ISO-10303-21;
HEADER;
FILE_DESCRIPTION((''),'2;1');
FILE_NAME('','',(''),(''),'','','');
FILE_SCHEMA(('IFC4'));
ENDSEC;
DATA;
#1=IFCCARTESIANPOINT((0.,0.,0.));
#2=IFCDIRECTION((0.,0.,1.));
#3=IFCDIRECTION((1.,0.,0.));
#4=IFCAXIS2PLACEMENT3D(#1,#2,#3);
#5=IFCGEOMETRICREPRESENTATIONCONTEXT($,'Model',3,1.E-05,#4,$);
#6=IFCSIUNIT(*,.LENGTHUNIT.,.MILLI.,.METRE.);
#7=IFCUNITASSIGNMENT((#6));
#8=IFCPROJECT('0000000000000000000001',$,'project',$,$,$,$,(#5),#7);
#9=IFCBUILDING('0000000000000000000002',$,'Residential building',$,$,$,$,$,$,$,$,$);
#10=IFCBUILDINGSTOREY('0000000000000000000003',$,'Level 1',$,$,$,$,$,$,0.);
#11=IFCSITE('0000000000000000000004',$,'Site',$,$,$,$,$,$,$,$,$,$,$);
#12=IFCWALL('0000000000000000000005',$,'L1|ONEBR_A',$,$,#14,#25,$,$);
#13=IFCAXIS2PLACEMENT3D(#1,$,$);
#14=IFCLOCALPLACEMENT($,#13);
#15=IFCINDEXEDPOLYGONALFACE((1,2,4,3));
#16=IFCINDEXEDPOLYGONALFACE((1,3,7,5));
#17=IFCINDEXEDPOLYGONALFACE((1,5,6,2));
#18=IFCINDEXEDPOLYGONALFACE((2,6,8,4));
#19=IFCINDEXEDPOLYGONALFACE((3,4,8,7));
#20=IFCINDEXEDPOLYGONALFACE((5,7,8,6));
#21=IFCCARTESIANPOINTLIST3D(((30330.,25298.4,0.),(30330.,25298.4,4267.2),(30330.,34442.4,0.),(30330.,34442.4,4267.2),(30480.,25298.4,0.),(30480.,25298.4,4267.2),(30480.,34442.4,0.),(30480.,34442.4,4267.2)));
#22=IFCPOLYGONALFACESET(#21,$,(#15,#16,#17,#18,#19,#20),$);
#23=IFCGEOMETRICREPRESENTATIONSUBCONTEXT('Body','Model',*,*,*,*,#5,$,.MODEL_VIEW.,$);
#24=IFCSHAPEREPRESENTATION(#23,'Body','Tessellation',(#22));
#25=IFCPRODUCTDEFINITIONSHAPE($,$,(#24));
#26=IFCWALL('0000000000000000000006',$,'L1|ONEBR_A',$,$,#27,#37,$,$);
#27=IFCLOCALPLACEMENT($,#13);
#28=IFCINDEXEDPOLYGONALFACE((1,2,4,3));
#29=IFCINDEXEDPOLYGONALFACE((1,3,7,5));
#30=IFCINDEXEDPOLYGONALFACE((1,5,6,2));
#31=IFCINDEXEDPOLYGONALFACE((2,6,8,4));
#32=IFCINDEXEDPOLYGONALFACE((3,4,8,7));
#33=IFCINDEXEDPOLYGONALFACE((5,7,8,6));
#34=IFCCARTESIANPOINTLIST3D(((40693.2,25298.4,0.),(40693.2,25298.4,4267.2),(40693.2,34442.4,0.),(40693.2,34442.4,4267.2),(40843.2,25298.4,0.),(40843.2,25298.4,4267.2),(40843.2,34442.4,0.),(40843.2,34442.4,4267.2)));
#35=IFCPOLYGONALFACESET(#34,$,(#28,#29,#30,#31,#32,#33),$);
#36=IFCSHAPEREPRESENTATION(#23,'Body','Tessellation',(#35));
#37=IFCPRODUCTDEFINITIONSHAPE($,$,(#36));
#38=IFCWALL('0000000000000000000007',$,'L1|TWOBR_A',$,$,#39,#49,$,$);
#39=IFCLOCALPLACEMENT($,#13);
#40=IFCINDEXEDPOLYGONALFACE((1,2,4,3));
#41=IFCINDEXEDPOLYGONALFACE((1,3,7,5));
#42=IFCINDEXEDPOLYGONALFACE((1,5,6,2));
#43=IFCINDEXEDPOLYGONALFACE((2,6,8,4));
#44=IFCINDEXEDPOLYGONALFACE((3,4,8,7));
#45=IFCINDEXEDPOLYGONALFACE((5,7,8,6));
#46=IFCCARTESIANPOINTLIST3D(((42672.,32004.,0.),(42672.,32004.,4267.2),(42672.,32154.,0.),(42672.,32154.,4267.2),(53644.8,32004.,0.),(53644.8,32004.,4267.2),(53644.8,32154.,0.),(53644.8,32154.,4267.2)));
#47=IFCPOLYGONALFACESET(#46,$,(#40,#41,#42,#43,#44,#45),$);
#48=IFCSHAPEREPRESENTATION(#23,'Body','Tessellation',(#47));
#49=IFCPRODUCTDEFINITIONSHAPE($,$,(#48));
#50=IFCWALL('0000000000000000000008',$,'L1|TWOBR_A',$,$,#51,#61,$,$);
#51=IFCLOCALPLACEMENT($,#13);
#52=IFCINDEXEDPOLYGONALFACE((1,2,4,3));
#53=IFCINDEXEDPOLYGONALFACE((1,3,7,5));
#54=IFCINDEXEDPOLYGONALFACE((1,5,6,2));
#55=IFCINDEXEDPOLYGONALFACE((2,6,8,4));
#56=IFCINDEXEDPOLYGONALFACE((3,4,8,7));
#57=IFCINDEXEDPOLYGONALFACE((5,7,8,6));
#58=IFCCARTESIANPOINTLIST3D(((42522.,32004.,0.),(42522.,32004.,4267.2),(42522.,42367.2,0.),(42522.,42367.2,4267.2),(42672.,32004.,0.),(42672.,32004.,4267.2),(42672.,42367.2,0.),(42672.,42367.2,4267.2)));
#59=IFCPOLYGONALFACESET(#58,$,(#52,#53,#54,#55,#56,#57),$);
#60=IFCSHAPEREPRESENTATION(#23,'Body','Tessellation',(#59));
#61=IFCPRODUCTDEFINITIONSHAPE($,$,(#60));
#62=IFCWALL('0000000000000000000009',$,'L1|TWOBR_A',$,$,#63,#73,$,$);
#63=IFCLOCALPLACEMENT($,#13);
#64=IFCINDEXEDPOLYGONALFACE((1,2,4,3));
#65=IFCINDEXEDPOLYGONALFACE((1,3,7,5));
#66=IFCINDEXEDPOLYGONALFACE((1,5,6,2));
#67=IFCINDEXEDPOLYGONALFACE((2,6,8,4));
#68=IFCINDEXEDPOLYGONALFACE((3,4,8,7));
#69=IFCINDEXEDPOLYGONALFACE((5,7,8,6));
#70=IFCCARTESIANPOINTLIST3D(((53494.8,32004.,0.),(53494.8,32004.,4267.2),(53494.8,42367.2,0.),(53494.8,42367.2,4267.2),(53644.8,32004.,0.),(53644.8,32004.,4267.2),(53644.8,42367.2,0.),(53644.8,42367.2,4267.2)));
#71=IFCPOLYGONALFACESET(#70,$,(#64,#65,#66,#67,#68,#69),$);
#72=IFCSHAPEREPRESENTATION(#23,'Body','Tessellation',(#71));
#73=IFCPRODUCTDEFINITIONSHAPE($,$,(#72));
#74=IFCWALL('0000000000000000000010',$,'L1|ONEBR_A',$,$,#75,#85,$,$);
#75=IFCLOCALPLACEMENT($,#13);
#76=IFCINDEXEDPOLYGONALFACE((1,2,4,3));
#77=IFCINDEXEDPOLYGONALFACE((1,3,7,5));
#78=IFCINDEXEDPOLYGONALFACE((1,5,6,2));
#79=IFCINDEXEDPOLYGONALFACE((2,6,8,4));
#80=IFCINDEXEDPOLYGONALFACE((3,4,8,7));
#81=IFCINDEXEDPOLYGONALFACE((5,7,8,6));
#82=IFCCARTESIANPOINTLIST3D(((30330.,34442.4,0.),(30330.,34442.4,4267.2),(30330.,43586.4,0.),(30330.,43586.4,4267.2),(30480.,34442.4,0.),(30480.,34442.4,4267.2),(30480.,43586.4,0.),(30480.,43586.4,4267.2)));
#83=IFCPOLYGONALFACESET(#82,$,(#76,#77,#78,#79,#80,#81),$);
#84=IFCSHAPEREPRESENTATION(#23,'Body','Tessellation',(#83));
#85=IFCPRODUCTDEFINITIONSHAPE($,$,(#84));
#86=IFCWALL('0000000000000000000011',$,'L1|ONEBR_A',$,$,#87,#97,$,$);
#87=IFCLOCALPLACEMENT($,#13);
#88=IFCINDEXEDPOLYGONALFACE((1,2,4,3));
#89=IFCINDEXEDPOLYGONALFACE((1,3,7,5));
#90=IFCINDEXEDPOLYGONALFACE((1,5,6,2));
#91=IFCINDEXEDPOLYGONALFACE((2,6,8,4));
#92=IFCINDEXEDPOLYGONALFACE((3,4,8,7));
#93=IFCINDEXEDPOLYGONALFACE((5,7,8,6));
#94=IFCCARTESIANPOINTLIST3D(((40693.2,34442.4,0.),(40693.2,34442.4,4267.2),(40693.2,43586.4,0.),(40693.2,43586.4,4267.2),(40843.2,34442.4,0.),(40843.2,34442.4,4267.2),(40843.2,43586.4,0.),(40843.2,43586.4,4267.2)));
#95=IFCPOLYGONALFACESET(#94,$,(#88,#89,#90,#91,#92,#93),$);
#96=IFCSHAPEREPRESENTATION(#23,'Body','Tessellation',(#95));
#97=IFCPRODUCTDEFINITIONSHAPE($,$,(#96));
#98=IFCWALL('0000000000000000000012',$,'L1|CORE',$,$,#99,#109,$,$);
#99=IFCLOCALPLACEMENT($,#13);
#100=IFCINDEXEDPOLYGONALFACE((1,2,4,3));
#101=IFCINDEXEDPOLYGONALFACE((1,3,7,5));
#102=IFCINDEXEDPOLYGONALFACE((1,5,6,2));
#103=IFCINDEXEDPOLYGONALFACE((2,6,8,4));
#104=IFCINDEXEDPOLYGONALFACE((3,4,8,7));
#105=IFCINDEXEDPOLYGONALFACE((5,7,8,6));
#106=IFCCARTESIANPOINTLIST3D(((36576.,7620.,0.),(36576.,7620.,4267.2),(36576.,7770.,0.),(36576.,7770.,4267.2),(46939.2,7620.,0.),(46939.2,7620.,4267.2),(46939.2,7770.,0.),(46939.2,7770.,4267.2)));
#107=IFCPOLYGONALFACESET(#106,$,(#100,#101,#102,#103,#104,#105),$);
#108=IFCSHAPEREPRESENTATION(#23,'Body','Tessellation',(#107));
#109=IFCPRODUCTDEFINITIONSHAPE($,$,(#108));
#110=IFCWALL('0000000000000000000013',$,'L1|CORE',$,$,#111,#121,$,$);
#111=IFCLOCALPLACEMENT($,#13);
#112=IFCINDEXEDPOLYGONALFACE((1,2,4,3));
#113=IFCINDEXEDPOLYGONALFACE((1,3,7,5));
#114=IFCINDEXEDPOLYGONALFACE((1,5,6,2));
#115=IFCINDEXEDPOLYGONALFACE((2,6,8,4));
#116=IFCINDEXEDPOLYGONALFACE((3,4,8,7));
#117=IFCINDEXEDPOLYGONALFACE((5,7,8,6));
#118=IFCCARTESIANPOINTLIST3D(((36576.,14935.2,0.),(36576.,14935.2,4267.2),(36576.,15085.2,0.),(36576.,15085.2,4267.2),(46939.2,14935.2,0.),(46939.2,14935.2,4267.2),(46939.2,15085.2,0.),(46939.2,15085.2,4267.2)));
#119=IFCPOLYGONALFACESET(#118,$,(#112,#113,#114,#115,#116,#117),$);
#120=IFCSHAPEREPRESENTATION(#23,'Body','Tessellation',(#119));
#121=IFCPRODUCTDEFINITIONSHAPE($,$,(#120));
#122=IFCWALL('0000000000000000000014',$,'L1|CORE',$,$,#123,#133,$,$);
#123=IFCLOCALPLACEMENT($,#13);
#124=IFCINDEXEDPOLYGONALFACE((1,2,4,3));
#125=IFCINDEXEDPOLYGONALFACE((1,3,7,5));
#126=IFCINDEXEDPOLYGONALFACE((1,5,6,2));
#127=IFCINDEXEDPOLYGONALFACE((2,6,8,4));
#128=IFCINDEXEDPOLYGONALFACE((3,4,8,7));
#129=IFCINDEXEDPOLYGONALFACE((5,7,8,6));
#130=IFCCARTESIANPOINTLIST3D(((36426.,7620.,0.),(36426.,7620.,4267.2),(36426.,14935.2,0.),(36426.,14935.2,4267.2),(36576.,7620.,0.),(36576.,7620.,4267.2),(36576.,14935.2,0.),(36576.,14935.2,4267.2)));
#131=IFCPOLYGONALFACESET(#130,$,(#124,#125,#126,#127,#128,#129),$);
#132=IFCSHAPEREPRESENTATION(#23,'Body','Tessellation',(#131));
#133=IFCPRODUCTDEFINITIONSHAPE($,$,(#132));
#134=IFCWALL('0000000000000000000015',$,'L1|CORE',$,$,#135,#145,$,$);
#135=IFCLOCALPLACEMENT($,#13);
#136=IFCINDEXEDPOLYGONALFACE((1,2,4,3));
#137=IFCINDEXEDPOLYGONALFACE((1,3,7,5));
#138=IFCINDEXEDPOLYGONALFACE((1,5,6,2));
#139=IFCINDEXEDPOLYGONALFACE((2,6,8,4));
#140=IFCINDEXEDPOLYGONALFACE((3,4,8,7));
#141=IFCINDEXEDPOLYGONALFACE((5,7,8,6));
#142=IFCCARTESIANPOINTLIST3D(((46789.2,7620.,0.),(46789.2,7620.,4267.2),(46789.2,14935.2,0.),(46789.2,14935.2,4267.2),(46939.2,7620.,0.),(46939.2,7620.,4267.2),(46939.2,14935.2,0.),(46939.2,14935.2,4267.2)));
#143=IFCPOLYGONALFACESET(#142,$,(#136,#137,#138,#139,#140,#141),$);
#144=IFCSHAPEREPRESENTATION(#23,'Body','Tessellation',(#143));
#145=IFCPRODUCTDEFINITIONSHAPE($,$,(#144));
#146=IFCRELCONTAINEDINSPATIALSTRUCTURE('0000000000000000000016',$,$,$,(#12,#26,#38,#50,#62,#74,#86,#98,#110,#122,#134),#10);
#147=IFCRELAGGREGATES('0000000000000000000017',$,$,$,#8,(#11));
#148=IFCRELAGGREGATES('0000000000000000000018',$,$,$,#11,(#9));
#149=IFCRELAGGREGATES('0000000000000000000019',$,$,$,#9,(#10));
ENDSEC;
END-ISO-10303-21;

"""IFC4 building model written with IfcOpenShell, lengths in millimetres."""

from ifc_helpers import new_model, si_unit, frame, origin_with_axes, place, context, subcontext, project, spatial, indexed_curve, outline, extrude, element, save


model = new_model("IFC4")

# Units and contexts
model_context = context("Model", 3, precision=1e-05, world=origin_with_axes())
body_context = subcontext(model_context, "Body", "Model", "MODEL_VIEW")
ifc_project = project(units=[si_unit("LENGTHUNIT", "METRE", prefix="MILLI")], contexts=[model_context])

# Site, building, storey
site = spatial("IfcSite", under=ifc_project, Name="Site")
building = spatial("IfcBuilding", under=site, Name="Residential building")
storey = spatial("IfcBuildingStorey", under=building, Name="Level 1", Elevation=0.0)

# Walls
for number, where, z_axis, x_axis, name in (
    (1, (30480.0, 25298.4, 0.0), (0.0, 0.0, 1.0), (0.0, 1.0, 0.0), "L1|ONEBR_A"),
    (2, (40843.2, 25298.4, 0.0), (0.0, 0.0, 1.0), (0.0, 1.0, 0.0), "L1|ONEBR_A"),
):
    element("IfcWall", number, at=place(None, frame(where, z_axis=z_axis, x_axis=x_axis)), inside=storey, Name=name, context=body_context, shape_type="SweptSolid", body=[
        extrude(outline(indexed_curve([(0.0, 0.0), (0.0, 150.0), (9144.0, 150.0), (9144.0, 0.0), (0.0, 0.0)], self_intersect=False)), origin_with_axes(), (0.0, 0.0, 1.0), 4267.2),
    ])
wall_placement = place(None, frame((42672.0, 32004.0, 0.0), z_axis=(0.0, 0.0, 1.0), x_axis=(1.0, 0.0, 0.0)))
element("IfcWall", 3, at=wall_placement, inside=storey, Name="L1|TWOBR_A", context=body_context, shape_type="SweptSolid", body=[
    extrude(outline(indexed_curve([(0.0, 0.0), (0.0, 150.0), (10972.8, 150.0), (10972.8, 0.0), (0.0, 0.0)], self_intersect=False)), origin_with_axes(), (0.0, 0.0, 1.0), 4267.2),
])
for number, where, z_axis, x_axis, name in (
    (4, (42672.0, 32004.0, 0.0), (0.0, 0.0, 1.0), (0.0, 1.0, 0.0), "L1|TWOBR_A"),
    (5, (53644.8, 32004.0, 0.0), (0.0, 0.0, 1.0), (0.0, 1.0, 0.0), "L1|TWOBR_A"),
):
    element("IfcWall", number, at=place(None, frame(where, z_axis=z_axis, x_axis=x_axis)), inside=storey, Name=name, context=body_context, shape_type="SweptSolid", body=[
        extrude(outline(indexed_curve([(0.0, 0.0), (0.0, 150.0), (10363.2, 150.0), (10363.2, 0.0), (0.0, 0.0)], self_intersect=False)), origin_with_axes(), (0.0, 0.0, 1.0), 4267.2),
    ])
for number, where, z_axis, x_axis, name in (
    (6, (30480.0, 34442.4, 0.0), (0.0, 0.0, 1.0), (0.0, 1.0, 0.0), "L1|ONEBR_A"),
    (7, (40843.2, 34442.4, 0.0), (0.0, 0.0, 1.0), (0.0, 1.0, 0.0), "L1|ONEBR_A"),
):
    element("IfcWall", number, at=place(None, frame(where, z_axis=z_axis, x_axis=x_axis)), inside=storey, Name=name, context=body_context, shape_type="SweptSolid", body=[
        extrude(outline(indexed_curve([(0.0, 0.0), (0.0, 150.0), (9144.0, 150.0), (9144.0, 0.0), (0.0, 0.0)], self_intersect=False)), origin_with_axes(), (0.0, 0.0, 1.0), 4267.2),
    ])
for number, where, z_axis, x_axis, name in (
    (8, (36576.0, 7620.0, 0.0), (0.0, 0.0, 1.0), (1.0, 0.0, 0.0), "L1|CORE"),
    (9, (36576.0, 14935.2, 0.0), (0.0, 0.0, 1.0), (1.0, 0.0, 0.0), "L1|CORE"),
):
    element("IfcWall", number, at=place(None, frame(where, z_axis=z_axis, x_axis=x_axis)), inside=storey, Name=name, context=body_context, shape_type="SweptSolid", body=[
        extrude(outline(indexed_curve([(0.0, 0.0), (0.0, 150.0), (10363.2, 150.0), (10363.2, 0.0), (0.0, 0.0)], self_intersect=False)), origin_with_axes(), (0.0, 0.0, 1.0), 4267.2),
    ])
for number, where, z_axis, x_axis, name in (
    (10, (36576.0, 7620.0, 0.0), (0.0, 0.0, 1.0), (0.0, 1.0, 0.0), "L1|CORE"),
    (11, (46939.2, 7620.0, 0.0), (0.0, 0.0, 1.0), (0.0, 1.0, 0.0), "L1|CORE"),
):
    element("IfcWall", number, at=place(None, frame(where, z_axis=z_axis, x_axis=x_axis)), inside=storey, Name=name, context=body_context, shape_type="SweptSolid", body=[
        extrude(outline(indexed_curve([(0.0, 0.0), (0.0, 150.0), (7315.2, 150.0), (7315.2, 0.0), (0.0, 0.0)], self_intersect=False)), origin_with_axes(), (0.0, 0.0, 1.0), 4267.2),
    ])

save(model, "model.ifc")
